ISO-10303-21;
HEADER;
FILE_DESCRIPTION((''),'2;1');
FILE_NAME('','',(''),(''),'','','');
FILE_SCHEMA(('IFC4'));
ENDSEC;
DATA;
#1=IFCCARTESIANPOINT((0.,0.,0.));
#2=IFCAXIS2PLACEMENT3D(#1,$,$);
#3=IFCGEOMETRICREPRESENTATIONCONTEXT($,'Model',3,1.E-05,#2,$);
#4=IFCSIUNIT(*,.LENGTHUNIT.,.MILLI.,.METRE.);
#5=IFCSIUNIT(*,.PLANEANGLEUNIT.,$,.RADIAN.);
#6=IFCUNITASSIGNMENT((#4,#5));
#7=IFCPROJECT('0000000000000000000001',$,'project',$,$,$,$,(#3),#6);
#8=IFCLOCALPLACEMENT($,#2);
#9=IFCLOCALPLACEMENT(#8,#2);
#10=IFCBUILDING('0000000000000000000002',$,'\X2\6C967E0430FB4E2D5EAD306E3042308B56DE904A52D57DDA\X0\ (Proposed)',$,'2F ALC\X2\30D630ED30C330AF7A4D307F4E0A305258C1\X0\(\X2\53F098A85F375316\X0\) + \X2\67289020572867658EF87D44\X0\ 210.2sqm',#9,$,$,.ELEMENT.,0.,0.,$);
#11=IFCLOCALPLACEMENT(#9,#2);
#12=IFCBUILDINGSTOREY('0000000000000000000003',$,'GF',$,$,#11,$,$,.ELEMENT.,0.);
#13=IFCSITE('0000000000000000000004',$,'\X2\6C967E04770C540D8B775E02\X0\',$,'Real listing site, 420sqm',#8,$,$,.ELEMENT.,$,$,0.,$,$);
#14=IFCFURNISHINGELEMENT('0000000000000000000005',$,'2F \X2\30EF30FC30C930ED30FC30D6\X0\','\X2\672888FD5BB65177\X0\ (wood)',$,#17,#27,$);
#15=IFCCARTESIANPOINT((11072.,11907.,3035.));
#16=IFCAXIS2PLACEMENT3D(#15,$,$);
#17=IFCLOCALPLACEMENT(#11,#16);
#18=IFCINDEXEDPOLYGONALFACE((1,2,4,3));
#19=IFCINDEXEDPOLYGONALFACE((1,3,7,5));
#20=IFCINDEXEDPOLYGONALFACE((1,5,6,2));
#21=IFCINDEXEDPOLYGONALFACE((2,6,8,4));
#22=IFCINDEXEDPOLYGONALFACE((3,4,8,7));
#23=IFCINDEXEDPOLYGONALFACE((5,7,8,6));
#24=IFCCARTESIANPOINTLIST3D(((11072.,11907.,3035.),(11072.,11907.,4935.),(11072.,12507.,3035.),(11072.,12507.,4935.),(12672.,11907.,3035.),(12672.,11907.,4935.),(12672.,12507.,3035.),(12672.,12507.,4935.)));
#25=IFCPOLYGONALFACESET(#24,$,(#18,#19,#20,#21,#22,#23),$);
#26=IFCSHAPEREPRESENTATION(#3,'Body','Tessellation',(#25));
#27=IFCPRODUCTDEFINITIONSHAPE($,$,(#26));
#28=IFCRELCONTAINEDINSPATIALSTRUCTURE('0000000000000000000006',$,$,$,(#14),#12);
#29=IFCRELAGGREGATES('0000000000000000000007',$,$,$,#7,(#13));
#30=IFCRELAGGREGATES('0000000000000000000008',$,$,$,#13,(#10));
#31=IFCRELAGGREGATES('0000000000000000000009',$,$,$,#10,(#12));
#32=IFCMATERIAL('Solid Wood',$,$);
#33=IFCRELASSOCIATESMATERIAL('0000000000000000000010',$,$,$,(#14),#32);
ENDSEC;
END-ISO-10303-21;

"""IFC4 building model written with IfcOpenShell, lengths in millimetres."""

from ifc_helpers import new_model, si_unit, frame, frame_2d, origin, place, context, project, spatial, rectangle, extrude, material, element, save


model = new_model("IFC4")

# Units and contexts
model_context = context("Model", 3, precision=1e-05, world=origin())
ifc_project = project(units=[si_unit("LENGTHUNIT", "METRE", prefix="MILLI"), si_unit("PLANEANGLEUNIT", "RADIAN")], contexts=[model_context])

# Site, building, storey
site_placement = place(None, origin())
site = spatial("IfcSite", under=ifc_project, at=site_placement, Name="沖縄県名護市", ObjectType="Real listing site, 420sqm", CompositionType="ELEMENT", RefElevation=0.0)
building_placement = place(site_placement, origin())
building = spatial("IfcBuilding", under=site, at=building_placement, Name="沖縄・中庭のある回遊動線 (Proposed)", ObjectType="2F ALCブロック積み上げ壁(台風強化) + 木造在来軸組 210.2sqm", CompositionType="ELEMENT", ElevationOfRefHeight=0.0, ElevationOfTerrain=0.0)
storey_placement = place(building_placement, origin())
storey = spatial("IfcBuildingStorey", under=building, at=storey_placement, Name="GF", CompositionType="ELEMENT", Elevation=0.0)

# Shared definitions
ifc_material_1 = material(Name="Solid Wood")

# Furnishing element
furnishing_1_placement = place(storey_placement, frame((11072.0, 11907.0, 3035.0)))
element("IfcFurnishingElement", 1, at=furnishing_1_placement, inside=storey, material=ifc_material_1, Name="2F ワードローブ", Description="木製家具 (wood)", context=model_context, shape_type="SweptSolid", body=[
    extrude(rectangle(XDim=1600.0, YDim=600.0, at=frame_2d((800.0, 300.0))), frame((11072.0, 11907.0, 3035.0)), (0.0, 0.0, 1.0), 1900.0),
])

save(model, "model.ifc")
